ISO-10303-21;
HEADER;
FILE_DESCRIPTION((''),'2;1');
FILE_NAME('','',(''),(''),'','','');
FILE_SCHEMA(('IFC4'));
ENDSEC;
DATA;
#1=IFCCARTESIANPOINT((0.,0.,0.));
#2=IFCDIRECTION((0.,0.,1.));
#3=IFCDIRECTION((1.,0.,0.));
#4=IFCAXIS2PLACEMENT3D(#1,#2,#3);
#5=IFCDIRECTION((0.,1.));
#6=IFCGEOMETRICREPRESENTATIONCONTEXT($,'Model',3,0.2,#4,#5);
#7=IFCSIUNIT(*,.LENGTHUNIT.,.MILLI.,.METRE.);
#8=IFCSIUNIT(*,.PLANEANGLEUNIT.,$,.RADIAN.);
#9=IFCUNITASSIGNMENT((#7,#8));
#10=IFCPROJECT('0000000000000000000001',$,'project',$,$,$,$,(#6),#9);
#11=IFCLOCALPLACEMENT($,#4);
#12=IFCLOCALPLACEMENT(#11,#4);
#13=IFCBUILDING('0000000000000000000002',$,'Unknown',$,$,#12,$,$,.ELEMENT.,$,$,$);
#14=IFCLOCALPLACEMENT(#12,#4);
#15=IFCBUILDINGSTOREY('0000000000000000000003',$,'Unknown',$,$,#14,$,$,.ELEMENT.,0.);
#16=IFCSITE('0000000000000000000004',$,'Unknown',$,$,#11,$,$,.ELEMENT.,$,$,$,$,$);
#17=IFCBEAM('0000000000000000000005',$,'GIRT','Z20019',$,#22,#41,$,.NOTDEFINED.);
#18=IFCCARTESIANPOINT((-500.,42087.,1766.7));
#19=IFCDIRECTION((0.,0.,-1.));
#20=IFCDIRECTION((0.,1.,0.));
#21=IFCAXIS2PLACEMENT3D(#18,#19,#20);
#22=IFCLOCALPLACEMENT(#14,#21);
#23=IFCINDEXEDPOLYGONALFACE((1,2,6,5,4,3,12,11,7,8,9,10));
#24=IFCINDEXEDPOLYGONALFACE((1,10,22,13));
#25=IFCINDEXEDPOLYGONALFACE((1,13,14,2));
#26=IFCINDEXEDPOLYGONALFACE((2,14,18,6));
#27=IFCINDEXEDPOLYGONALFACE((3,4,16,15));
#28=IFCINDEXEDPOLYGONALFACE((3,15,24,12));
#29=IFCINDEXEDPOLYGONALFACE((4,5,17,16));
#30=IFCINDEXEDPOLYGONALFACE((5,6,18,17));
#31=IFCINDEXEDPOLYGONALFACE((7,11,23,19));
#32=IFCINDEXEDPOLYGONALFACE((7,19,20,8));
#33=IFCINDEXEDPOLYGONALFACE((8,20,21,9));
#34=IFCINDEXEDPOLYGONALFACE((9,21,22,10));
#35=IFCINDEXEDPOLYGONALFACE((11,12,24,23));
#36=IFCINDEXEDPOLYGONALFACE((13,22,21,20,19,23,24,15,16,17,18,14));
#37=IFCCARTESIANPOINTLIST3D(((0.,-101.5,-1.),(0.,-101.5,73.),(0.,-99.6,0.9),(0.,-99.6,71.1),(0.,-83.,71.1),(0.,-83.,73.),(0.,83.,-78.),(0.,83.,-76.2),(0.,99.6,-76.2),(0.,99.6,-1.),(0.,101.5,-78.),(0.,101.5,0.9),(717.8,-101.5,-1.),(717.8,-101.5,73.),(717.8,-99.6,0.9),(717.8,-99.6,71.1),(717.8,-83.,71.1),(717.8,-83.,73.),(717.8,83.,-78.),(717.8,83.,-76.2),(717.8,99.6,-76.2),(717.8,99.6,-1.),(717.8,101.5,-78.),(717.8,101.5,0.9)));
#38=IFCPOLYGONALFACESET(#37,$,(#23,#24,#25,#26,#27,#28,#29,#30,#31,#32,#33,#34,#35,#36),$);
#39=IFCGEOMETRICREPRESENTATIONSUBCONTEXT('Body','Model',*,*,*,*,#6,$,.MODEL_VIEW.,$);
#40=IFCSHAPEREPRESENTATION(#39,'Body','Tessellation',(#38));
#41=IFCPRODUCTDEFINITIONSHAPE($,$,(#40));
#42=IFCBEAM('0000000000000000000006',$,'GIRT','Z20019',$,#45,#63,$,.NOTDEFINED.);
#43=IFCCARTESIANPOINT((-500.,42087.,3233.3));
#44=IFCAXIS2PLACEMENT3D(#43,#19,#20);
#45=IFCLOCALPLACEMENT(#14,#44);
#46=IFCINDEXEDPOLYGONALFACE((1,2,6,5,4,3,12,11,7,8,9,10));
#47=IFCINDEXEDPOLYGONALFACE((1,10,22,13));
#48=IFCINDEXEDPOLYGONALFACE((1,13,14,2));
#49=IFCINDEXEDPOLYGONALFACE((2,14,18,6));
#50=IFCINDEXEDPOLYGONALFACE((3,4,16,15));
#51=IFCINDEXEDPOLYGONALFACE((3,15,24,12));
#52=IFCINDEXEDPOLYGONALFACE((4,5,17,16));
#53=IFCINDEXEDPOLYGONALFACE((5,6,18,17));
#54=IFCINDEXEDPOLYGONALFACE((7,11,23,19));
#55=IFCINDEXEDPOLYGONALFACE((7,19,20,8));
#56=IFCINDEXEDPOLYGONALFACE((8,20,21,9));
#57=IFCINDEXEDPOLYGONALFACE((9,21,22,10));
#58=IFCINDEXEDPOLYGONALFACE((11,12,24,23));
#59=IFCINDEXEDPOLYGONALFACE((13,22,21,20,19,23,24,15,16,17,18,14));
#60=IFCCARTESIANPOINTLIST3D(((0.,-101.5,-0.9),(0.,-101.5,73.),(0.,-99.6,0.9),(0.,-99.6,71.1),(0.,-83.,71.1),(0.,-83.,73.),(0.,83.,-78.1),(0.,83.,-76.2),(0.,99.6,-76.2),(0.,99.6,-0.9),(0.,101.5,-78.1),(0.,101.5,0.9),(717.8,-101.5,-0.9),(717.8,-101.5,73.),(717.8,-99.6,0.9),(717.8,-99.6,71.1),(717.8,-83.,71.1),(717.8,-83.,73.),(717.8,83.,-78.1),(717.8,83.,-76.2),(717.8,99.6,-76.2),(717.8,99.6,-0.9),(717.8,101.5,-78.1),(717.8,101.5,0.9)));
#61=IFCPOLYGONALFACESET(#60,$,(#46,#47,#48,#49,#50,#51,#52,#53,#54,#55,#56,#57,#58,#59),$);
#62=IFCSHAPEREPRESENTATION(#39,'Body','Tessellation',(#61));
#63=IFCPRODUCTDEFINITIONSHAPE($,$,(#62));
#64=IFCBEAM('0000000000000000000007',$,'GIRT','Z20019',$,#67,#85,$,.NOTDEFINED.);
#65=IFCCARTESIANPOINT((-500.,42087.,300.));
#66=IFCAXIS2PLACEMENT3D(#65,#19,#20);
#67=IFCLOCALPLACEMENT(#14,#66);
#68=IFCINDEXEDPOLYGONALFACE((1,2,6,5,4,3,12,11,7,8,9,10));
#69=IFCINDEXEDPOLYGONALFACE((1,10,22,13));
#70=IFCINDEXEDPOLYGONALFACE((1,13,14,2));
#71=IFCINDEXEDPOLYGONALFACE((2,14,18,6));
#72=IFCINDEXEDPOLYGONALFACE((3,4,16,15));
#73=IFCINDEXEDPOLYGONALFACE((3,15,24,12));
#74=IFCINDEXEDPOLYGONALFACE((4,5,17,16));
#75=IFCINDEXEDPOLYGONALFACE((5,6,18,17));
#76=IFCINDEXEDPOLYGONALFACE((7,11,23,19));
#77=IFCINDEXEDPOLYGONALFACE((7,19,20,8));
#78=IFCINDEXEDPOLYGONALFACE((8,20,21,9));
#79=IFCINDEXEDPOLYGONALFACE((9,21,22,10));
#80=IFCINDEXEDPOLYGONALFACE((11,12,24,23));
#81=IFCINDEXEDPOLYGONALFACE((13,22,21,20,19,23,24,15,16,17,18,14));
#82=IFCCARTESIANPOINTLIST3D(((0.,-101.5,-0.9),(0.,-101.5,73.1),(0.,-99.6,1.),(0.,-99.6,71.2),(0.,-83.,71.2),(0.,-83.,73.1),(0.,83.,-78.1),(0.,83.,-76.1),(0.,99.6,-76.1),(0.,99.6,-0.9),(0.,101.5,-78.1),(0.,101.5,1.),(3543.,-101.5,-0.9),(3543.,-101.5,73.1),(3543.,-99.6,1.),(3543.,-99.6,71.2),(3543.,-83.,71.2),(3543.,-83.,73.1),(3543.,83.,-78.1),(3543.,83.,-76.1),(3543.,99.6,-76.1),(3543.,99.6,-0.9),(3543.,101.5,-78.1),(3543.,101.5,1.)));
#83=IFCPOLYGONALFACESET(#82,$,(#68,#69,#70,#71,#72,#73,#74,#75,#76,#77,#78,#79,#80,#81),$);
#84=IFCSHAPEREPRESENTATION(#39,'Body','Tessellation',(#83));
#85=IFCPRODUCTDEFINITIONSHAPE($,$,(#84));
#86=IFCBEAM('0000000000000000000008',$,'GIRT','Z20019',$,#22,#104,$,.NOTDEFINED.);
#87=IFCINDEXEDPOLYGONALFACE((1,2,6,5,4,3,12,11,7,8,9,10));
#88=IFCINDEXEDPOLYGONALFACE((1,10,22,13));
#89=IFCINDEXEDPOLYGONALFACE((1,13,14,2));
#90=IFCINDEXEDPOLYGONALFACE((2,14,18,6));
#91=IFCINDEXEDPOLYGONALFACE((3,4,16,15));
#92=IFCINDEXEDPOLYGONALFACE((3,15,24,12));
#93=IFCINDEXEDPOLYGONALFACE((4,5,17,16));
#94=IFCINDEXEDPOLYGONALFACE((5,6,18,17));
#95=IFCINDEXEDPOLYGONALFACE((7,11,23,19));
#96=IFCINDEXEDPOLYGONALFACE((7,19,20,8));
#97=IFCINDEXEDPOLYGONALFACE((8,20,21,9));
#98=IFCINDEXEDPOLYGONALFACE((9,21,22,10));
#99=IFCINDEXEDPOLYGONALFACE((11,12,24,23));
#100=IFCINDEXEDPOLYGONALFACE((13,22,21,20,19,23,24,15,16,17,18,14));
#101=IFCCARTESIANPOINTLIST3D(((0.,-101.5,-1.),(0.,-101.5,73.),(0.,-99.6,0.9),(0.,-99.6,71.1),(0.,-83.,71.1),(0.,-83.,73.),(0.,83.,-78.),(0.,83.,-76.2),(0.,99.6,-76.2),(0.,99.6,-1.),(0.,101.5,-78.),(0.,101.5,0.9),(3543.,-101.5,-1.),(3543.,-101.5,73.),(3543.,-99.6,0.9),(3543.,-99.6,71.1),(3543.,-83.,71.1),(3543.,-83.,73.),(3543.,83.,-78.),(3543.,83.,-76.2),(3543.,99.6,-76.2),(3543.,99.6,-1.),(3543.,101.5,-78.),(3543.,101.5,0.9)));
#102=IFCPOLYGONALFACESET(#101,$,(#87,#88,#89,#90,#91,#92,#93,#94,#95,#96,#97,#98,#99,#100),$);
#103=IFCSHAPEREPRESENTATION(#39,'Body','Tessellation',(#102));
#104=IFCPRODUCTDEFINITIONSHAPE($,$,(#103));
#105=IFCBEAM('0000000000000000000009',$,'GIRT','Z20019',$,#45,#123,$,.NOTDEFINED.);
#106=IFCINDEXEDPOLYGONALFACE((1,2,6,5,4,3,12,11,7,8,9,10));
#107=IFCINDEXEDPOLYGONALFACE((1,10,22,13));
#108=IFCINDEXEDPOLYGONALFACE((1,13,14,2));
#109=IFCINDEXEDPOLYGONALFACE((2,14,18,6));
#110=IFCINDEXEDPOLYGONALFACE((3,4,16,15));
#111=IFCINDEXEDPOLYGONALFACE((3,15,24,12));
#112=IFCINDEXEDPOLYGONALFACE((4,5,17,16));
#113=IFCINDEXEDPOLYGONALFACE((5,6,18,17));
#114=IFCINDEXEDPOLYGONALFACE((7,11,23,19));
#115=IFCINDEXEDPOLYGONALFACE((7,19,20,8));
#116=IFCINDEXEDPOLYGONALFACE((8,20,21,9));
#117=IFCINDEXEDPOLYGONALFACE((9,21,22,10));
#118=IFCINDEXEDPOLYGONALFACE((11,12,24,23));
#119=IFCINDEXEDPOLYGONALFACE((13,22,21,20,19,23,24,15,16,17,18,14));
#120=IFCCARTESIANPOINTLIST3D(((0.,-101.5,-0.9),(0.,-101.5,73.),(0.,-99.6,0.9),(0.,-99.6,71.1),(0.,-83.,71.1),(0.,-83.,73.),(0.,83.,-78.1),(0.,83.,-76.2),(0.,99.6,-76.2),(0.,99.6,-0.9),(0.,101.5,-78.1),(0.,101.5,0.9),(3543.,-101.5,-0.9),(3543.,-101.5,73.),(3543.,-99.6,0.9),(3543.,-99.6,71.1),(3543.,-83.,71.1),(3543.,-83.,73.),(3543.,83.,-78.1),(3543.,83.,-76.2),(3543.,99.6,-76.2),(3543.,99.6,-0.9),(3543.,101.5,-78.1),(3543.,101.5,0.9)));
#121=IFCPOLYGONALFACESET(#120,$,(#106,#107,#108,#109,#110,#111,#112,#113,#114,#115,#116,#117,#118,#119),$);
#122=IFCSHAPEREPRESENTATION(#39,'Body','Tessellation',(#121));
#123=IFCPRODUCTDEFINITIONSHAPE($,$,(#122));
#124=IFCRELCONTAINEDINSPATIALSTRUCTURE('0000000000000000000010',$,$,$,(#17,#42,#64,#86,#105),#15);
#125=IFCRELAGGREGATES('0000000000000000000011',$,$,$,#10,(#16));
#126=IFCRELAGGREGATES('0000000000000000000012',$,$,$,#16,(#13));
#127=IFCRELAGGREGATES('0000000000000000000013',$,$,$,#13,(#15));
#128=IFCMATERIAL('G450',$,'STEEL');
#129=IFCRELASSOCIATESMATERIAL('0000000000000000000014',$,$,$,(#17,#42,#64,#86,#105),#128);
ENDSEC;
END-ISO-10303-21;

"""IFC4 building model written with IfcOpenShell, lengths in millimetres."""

from ifc_helpers import new_model, si_unit, direction, frame, origin_with_axes, place, context, subcontext, project, spatial, line, indexed_curve, outline, extrude, material, element, save


model = new_model("IFC4")

# Units and contexts
model_context = context("Model", 3, precision=0.2, world=origin_with_axes(), true_north=direction((0.0, 1.0)))
body_context = subcontext(model_context, "Body", "Model", "MODEL_VIEW")
ifc_project = project(units=[si_unit("LENGTHUNIT", "METRE", prefix="MILLI"), si_unit("PLANEANGLEUNIT", "RADIAN")], contexts=[model_context])

# Site, building, storey
site_placement = place(None, origin_with_axes())
site = spatial("IfcSite", under=ifc_project, at=site_placement, Name="Unknown", CompositionType="ELEMENT")
building_placement = place(site_placement, origin_with_axes())
building = spatial("IfcBuilding", under=site, at=building_placement, Name="Unknown", CompositionType="ELEMENT")
storey_placement = place(building_placement, origin_with_axes())
storey = spatial("IfcBuildingStorey", under=building, at=storey_placement, Name="Unknown", CompositionType="ELEMENT", Elevation=0.0)

# Shared definitions
ifc_material_1 = material(Name="G450", Category="STEEL")

# Beams
placement_1 = place(storey_placement, frame((-500.0, 42087.0, 1766.7), z_axis=(0.0, 0.0, -1.0), x_axis=(0.0, 1.0, 0.0)))
element("IfcBeam", 1, at=placement_1, inside=storey, material=ifc_material_1, Name="GIRT", Description="Z20019", PredefinedType="NOTDEFINED", context=body_context, shape_type="SolidModel", body=[
    extrude(outline(indexed_curve([(73.0, -101.5), (73.0, -83.0), (71.2, -83.0), (71.2, -99.6), (0.9, -99.6), (0.9, 101.5), (-78.0, 101.5), (-78.0, 83.0), (-76.2, 83.0), (-76.2, 99.6), (-0.9, 99.6), (-0.9, -101.5)], segments=[line(1, 2, 3, 4, 5, 6, 7, 8, 9, 10, 11, 12, 1)])), frame((0.0, 0.0, 0.0), z_axis=(-1.0, 0.0, 0.0), x_axis=(0.0, 0.0, 1.0)), (0.0, 0.0, -1.0), 717.8),
])
placement_2 = place(storey_placement, frame((-500.0, 42087.0, 3233.3), z_axis=(0.0, 0.0, -1.0), x_axis=(0.0, 1.0, 0.0)))
element("IfcBeam", 2, at=placement_2, inside=storey, material=ifc_material_1, Name="GIRT", Description="Z20019", PredefinedType="NOTDEFINED", context=body_context, shape_type="SolidModel", body=[
    extrude(outline(indexed_curve([(73.0, -101.5), (73.0, -83.0), (71.2, -83.0), (71.2, -99.6), (0.9, -99.6), (0.9, 101.5), (-78.0, 101.5), (-78.0, 83.0), (-76.2, 83.0), (-76.2, 99.6), (-0.9, 99.6), (-0.9, -101.5)], segments=[line(1, 2, 3, 4, 5, 6, 7, 8, 9, 10, 11, 12, 1)])), frame((0.0, 0.0, 0.0), z_axis=(-1.0, 0.0, 0.0), x_axis=(0.0, 0.0, 1.0)), (0.0, 0.0, -1.0), 717.8),
])
beam_1_placement = place(storey_placement, frame((-500.0, 42087.0, 300.0), z_axis=(0.0, 0.0, -1.0), x_axis=(0.0, 1.0, 0.0)))
element("IfcBeam", 3, at=beam_1_placement, inside=storey, material=ifc_material_1, Name="GIRT", Description="Z20019", PredefinedType="NOTDEFINED", context=body_context, shape_type="SolidModel", body=[
    extrude(outline(indexed_curve([(73.0, -101.5), (73.0, -83.0), (71.2, -83.0), (71.2, -99.6), (0.9, -99.6), (0.9, 101.5), (-78.0, 101.5), (-78.0, 83.0), (-76.2, 83.0), (-76.2, 99.6), (-0.9, 99.6), (-0.9, -101.5)], segments=[line(1, 2, 3, 4, 5, 6, 7, 8, 9, 10, 11, 12, 1)])), frame((0.0, 0.0, 0.0), z_axis=(-1.0, 0.0, 0.0), x_axis=(0.0, 0.0, 1.0)), (0.0, 0.0, -1.0), 3543.0),
])
element("IfcBeam", 4, at=placement_1, inside=storey, material=ifc_material_1, Name="GIRT", Description="Z20019", PredefinedType="NOTDEFINED", context=body_context, shape_type="SolidModel", body=[
    extrude(outline(indexed_curve([(73.0, -101.5), (73.0, -83.0), (71.2, -83.0), (71.2, -99.6), (0.9, -99.6), (0.9, 101.5), (-78.0, 101.5), (-78.0, 83.0), (-76.2, 83.0), (-76.2, 99.6), (-0.9, 99.6), (-0.9, -101.5)], segments=[line(1, 2, 3, 4, 5, 6, 7, 8, 9, 10, 11, 12, 1)])), frame((0.0, 0.0, 0.0), z_axis=(-1.0, 0.0, 0.0), x_axis=(0.0, 0.0, 1.0)), (0.0, 0.0, -1.0), 3543.0),
])
element("IfcBeam", 5, at=placement_2, inside=storey, material=ifc_material_1, Name="GIRT", Description="Z20019", PredefinedType="NOTDEFINED", context=body_context, shape_type="SolidModel", body=[
    extrude(outline(indexed_curve([(73.0, -101.5), (73.0, -83.0), (71.2, -83.0), (71.2, -99.6), (0.9, -99.6), (0.9, 101.5), (-78.0, 101.5), (-78.0, 83.0), (-76.2, 83.0), (-76.2, 99.6), (-0.9, 99.6), (-0.9, -101.5)], segments=[line(1, 2, 3, 4, 5, 6, 7, 8, 9, 10, 11, 12, 1)])), frame((0.0, 0.0, 0.0), z_axis=(-1.0, 0.0, 0.0), x_axis=(0.0, 0.0, 1.0)), (0.0, 0.0, -1.0), 3543.0),
])

save(model, "model.ifc")
